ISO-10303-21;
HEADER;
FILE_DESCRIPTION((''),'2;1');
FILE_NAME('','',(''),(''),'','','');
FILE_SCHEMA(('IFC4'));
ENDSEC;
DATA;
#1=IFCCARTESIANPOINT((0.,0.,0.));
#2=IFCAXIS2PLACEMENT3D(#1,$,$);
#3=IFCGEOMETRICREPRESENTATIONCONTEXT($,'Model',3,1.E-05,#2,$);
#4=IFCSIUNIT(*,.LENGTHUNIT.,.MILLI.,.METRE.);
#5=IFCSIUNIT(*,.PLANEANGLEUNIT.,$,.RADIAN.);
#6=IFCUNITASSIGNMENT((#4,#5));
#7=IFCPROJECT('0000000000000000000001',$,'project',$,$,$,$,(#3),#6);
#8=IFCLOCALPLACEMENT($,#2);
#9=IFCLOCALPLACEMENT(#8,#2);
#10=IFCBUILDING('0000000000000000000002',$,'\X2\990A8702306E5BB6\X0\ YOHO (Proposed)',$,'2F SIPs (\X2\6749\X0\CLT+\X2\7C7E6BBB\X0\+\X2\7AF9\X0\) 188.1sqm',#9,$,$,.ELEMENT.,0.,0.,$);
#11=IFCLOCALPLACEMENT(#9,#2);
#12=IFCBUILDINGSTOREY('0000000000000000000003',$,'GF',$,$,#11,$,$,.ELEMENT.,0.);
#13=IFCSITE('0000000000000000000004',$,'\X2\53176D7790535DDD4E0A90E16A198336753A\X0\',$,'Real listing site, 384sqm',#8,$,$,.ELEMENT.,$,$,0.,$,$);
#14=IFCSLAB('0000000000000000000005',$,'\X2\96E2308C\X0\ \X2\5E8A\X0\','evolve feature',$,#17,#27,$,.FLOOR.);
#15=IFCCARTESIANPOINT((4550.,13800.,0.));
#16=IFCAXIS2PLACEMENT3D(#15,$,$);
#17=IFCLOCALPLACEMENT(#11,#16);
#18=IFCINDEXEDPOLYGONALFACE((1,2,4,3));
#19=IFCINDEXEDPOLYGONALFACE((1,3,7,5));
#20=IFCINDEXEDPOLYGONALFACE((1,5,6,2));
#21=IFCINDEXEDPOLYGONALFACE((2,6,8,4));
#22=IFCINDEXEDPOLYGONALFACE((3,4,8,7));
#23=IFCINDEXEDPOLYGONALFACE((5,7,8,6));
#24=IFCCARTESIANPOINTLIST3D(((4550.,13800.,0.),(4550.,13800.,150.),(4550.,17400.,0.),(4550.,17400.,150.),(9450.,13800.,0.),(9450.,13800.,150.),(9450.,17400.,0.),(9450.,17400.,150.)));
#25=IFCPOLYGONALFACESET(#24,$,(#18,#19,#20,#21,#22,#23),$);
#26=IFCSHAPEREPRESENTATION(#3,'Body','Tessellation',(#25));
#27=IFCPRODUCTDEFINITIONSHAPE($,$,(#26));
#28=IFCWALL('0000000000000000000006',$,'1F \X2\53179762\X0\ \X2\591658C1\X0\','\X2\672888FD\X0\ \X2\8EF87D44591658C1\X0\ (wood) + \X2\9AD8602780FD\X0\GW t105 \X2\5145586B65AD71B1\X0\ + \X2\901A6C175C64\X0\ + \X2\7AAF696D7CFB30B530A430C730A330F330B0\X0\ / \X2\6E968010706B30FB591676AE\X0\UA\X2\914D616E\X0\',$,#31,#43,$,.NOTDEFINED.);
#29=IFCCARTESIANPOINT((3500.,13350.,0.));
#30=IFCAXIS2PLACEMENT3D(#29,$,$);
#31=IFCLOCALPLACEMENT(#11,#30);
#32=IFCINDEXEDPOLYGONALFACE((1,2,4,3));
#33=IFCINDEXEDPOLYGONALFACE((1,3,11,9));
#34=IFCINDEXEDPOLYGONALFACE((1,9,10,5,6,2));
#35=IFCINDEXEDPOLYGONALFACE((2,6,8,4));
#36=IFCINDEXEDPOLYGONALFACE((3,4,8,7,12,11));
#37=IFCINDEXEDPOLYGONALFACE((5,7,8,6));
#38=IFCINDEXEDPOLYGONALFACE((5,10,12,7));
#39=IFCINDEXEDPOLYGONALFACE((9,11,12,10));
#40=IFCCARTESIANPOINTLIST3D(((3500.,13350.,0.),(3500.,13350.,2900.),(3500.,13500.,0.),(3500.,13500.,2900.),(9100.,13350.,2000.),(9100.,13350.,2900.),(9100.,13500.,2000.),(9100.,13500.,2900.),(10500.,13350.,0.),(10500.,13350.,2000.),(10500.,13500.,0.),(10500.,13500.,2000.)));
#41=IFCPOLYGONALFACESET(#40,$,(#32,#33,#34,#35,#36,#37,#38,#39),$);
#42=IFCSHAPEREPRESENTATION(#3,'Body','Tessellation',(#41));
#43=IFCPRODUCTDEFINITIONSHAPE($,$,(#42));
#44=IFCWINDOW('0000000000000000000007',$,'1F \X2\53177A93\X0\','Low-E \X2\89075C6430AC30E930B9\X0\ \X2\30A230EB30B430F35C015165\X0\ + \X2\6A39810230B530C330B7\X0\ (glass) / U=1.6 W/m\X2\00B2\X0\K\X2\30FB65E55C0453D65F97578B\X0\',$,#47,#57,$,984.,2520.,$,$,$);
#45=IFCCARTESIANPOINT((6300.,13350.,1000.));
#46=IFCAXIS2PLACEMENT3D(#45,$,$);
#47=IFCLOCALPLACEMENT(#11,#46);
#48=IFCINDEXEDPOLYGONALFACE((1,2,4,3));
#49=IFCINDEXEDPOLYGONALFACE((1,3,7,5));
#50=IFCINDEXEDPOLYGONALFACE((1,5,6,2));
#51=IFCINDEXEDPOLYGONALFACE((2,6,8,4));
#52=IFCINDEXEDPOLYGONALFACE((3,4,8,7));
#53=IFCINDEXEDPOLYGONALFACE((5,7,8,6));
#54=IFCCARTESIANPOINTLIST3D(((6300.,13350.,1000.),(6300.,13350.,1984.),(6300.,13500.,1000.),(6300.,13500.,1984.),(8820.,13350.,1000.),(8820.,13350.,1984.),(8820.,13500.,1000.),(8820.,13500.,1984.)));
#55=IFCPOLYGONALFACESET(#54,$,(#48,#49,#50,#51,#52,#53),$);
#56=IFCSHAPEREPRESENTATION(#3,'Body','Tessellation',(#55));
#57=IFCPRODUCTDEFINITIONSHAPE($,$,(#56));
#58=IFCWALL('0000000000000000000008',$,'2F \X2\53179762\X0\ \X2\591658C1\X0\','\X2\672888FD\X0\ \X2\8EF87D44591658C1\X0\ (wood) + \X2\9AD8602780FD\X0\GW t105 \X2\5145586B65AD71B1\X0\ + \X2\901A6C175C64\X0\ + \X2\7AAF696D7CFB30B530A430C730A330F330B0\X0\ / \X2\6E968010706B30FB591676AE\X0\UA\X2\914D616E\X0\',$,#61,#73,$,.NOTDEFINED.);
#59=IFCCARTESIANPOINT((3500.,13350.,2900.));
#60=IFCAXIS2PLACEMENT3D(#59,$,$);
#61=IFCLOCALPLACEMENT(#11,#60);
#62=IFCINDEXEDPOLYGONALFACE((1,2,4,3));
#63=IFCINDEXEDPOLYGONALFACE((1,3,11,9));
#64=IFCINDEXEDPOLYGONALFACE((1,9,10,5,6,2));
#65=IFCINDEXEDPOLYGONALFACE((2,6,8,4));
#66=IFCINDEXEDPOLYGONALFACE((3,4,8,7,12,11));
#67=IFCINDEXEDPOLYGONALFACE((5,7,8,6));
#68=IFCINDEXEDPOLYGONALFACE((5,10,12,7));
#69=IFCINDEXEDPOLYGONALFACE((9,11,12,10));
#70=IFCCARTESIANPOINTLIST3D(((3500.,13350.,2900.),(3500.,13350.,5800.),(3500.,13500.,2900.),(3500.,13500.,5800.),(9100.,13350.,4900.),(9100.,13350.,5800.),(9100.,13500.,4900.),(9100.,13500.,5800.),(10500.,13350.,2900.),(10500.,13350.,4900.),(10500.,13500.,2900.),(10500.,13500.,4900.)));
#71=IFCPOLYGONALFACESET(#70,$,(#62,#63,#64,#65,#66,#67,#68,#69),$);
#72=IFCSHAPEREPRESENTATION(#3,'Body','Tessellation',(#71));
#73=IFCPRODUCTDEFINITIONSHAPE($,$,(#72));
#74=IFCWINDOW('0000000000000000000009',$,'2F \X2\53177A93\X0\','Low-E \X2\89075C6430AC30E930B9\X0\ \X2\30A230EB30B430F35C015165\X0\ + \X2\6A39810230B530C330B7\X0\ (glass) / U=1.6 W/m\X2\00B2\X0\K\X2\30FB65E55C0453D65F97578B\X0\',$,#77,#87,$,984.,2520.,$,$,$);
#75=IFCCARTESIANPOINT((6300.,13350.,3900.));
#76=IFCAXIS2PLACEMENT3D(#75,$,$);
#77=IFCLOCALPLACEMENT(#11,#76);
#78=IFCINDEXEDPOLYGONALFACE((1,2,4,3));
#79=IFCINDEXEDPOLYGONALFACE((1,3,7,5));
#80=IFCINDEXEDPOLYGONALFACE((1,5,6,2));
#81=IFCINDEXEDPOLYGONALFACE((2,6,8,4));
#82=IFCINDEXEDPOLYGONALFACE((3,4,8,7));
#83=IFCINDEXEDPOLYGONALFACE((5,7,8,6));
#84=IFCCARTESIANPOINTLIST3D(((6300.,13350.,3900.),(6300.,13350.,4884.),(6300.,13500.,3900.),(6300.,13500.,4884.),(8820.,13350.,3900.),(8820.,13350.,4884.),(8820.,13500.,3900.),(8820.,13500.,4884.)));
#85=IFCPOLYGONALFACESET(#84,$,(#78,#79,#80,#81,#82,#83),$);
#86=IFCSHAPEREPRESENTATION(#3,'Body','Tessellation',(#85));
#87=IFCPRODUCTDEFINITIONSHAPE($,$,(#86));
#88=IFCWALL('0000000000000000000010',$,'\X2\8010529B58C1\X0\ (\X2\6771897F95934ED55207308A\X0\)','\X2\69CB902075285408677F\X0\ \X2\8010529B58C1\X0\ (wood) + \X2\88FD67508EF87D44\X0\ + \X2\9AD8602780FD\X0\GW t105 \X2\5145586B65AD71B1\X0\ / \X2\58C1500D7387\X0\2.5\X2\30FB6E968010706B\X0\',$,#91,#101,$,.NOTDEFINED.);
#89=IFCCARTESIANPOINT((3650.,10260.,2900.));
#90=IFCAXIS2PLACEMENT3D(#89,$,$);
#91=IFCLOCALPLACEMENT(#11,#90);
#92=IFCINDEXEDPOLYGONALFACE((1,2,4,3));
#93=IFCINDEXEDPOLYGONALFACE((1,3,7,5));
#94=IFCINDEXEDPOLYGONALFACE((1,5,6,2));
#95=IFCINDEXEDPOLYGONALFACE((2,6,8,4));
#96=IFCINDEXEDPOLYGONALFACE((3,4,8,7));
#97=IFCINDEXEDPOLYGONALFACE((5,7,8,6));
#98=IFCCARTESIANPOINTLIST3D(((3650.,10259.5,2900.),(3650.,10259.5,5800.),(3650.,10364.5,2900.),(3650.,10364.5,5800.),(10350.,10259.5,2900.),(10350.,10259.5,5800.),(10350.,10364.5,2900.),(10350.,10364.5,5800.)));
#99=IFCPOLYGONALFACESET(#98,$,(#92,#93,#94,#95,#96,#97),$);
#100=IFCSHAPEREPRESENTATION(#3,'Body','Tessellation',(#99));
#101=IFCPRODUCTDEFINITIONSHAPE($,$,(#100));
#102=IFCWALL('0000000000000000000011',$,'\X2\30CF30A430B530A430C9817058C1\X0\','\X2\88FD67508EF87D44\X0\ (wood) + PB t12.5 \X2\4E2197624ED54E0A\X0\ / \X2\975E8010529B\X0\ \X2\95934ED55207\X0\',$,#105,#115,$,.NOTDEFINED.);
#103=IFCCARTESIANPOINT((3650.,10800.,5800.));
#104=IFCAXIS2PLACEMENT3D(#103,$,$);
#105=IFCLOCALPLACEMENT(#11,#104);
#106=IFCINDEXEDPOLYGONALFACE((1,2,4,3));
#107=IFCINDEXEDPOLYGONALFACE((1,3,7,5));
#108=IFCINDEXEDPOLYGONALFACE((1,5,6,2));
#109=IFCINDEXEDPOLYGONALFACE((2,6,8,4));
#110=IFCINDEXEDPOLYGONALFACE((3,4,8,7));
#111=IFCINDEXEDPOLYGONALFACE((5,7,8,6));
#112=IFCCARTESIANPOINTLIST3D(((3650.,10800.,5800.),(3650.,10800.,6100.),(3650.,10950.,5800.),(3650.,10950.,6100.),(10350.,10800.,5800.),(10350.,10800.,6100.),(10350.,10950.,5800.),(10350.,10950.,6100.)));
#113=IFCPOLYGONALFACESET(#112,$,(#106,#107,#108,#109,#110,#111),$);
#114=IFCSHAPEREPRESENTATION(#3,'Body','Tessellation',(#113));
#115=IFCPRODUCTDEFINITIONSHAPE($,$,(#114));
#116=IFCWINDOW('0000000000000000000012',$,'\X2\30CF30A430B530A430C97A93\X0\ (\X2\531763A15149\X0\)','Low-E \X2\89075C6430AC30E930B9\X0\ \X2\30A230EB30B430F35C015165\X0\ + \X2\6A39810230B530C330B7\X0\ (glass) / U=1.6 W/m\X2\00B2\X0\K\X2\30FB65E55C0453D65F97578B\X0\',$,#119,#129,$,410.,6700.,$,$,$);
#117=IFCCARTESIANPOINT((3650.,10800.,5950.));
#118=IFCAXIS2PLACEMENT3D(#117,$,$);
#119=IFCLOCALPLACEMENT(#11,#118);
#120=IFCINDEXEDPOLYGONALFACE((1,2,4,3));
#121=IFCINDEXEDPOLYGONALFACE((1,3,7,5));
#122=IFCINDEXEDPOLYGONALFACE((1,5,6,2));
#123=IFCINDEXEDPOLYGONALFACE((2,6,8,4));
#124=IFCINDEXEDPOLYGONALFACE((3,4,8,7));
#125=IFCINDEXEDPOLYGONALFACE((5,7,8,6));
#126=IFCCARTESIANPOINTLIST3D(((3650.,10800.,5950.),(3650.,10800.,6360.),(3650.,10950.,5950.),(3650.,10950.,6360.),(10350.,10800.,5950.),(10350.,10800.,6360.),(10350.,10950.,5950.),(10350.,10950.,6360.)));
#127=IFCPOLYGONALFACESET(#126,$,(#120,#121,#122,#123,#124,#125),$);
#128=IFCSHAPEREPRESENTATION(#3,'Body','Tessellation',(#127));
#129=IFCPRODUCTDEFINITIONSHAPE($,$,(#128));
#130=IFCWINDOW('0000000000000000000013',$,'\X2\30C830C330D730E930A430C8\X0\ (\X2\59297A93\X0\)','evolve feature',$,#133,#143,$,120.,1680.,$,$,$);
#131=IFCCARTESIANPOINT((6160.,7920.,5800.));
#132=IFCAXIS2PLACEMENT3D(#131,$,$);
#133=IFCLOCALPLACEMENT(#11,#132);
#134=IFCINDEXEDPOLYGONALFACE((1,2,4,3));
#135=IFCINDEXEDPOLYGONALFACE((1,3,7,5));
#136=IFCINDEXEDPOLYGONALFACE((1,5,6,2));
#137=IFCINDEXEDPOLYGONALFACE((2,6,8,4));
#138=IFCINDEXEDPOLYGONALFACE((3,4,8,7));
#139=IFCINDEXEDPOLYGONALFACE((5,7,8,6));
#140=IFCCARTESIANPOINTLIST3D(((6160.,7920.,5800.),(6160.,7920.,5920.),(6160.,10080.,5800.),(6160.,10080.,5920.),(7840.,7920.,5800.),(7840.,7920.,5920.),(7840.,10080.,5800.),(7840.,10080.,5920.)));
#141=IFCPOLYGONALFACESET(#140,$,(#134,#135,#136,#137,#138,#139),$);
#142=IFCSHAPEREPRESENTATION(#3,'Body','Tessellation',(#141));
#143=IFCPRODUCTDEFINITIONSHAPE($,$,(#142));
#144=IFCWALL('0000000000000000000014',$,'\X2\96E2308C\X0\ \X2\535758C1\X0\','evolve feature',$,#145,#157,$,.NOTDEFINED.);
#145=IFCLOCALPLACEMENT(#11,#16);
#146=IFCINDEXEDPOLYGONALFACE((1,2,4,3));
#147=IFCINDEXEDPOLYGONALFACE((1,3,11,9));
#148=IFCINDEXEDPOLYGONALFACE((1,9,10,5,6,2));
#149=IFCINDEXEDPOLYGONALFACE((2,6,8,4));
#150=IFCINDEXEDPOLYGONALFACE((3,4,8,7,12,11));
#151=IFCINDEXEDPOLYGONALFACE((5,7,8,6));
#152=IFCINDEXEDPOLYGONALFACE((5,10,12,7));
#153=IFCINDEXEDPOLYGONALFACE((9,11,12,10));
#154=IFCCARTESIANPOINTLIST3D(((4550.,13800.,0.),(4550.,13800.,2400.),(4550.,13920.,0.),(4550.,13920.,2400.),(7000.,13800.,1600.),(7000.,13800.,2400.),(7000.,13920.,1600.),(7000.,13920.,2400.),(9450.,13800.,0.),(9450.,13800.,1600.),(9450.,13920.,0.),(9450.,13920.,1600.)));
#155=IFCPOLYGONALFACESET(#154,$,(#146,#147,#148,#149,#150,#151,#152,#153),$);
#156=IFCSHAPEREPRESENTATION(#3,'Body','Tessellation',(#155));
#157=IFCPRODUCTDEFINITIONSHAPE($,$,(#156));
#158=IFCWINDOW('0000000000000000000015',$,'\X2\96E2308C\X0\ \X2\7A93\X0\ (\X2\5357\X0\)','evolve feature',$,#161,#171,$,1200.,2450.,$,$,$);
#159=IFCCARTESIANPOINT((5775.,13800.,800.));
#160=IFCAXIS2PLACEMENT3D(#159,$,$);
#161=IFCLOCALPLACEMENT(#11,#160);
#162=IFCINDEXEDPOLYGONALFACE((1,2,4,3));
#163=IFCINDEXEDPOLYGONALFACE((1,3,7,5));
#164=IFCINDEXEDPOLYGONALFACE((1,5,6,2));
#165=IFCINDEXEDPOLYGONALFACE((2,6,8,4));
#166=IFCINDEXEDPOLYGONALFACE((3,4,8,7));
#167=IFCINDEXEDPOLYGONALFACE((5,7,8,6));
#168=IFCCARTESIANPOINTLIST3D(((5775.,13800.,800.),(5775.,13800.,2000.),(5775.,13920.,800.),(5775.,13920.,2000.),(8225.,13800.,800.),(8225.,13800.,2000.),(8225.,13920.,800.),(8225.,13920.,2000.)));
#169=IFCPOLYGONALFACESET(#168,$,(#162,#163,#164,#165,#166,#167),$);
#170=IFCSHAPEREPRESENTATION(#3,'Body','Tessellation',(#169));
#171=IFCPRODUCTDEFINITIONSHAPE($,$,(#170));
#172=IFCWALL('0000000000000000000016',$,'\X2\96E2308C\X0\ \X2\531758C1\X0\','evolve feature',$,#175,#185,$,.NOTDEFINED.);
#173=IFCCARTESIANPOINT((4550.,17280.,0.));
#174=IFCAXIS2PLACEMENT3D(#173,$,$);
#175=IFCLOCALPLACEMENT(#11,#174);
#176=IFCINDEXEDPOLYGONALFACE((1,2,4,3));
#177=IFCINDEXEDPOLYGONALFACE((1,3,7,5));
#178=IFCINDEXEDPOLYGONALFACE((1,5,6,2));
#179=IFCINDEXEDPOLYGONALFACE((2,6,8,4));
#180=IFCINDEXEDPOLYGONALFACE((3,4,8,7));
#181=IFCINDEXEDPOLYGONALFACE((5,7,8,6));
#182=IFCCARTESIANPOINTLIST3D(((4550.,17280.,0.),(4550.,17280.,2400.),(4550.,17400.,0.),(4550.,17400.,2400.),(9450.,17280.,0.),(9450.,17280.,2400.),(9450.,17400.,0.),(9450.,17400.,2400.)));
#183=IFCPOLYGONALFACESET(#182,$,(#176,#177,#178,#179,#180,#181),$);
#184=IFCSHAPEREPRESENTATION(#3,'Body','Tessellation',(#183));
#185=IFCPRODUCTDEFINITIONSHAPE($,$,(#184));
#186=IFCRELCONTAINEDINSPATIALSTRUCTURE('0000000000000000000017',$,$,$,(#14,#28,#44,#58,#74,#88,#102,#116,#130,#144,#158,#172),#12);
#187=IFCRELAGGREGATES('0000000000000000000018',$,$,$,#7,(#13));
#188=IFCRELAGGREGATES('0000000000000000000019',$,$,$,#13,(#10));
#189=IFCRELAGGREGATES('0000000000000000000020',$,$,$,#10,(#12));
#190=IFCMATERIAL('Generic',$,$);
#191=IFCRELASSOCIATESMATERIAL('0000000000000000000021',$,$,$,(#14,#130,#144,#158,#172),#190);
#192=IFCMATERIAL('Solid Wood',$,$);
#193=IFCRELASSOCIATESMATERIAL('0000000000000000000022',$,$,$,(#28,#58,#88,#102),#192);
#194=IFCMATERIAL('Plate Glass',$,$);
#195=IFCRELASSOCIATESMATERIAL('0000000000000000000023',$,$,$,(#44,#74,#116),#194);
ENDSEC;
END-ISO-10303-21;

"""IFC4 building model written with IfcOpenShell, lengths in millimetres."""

from ifc_helpers import new_model, si_unit, frame, frame_2d, origin, place, context, project, spatial, rectangle, extrude, material, element, fill, save


model = new_model("IFC4")

# Units and contexts
model_context = context("Model", 3, precision=1e-05, world=origin())
ifc_project = project(units=[si_unit("LENGTHUNIT", "METRE", prefix="MILLI"), si_unit("PLANEANGLEUNIT", "RADIAN")], contexts=[model_context])

# Site, building, storey
site_placement = place(None, origin())
site = spatial("IfcSite", under=ifc_project, at=site_placement, Name="北海道川上郡標茶町", ObjectType="Real listing site, 384sqm", CompositionType="ELEMENT", RefElevation=0.0)
building_placement = place(site_placement, origin())
building = spatial("IfcBuilding", under=site, at=building_placement, Name="養蜂の家 YOHO (Proposed)", ObjectType="2F SIPs (杉CLT+籾殻+竹) 188.1sqm", CompositionType="ELEMENT", ElevationOfRefHeight=0.0, ElevationOfTerrain=0.0)
storey_placement = place(building_placement, origin())
storey = spatial("IfcBuildingStorey", under=building, at=storey_placement, Name="GF", CompositionType="ELEMENT", Elevation=0.0)

# Slab
ifc_material_1 = material(Name="Generic")
slab_placement = place(storey_placement, frame((4550.0, 13800.0, 0.0)))
element("IfcSlab", 1, at=slab_placement, inside=storey, material=ifc_material_1, Name="離れ 床", Description="evolve feature", PredefinedType="FLOOR", context=model_context, shape_type="SweptSolid", body=[
    extrude(rectangle(XDim=4900.0, YDim=3600.0, at=frame_2d((2450.0, 1800.0))), frame((4550.0, 13800.0, 0.0)), (0.0, 0.0, 1.0), 150.0),
])

# Wall, opening, window
ifc_material_2 = material(Name="Solid Wood")
wall_1_placement = place(storey_placement, frame((3500.0, 13350.0, 0.0)))
wall_1 = element("IfcWall", 2, at=wall_1_placement, inside=storey, material=ifc_material_2, Name="1F 北面 外壁", Description="木製 軸組外壁 (wood) + 高性能GW t105 充填断熱 + 通気層 + 窯業系サイディング / 準耐火・外皮UA配慮", PredefinedType="NOTDEFINED", context=model_context, shape_type="SweptSolid", body=[
    extrude(rectangle(XDim=7000.0, YDim=150.0, at=frame_2d((3500.0, 75.0))), frame((3500.0, 13350.0, 0.0)), (0.0, 0.0, 1.0), 2900.0),
])
opening_1_placement = place(storey_placement, frame((6300.0, 13350.0, 1000.0)))
opening_1 = element("IfcOpeningElement", 3, at=opening_1_placement, cuts=wall_1, PredefinedType="NOTDEFINED", context=model_context, shape_type="SweptSolid", body=[
    extrude(rectangle(XDim=2520.0, YDim=150.0, at=frame_2d((1260.0, 75.0))), frame((6300.0, 13350.0, 1000.0)), (0.0, 0.0, 1.0), 984.0),
])
ifc_material_3 = material(Name="Plate Glass")
window_1_placement = place(storey_placement, frame((6300.0, 13350.0, 1000.0)))
window_1 = element("IfcWindow", 4, at=window_1_placement, inside=storey, material=ifc_material_3, Name="1F 北窓", Description="Low-E 複層ガラス アルゴン封入 + 樹脂サッシ (glass) / U=1.6 W/m²K・日射取得型", OverallHeight=984.0, OverallWidth=2520.0, context=model_context, shape_type="SweptSolid", body=[
    extrude(rectangle(XDim=2520.0, YDim=150.0, at=frame_2d((1260.0, 75.0))), frame((6300.0, 13350.0, 1000.0)), (0.0, 0.0, 1.0), 984.0),
])
fill(opening_1, window_1)

# Wall, opening, window
wall_2_placement = place(storey_placement, frame((3500.0, 13350.0, 2900.0)))
wall_2 = element("IfcWall", 5, at=wall_2_placement, inside=storey, material=ifc_material_2, Name="2F 北面 外壁", Description="木製 軸組外壁 (wood) + 高性能GW t105 充填断熱 + 通気層 + 窯業系サイディング / 準耐火・外皮UA配慮", PredefinedType="NOTDEFINED", context=model_context, shape_type="SweptSolid", body=[
    extrude(rectangle(XDim=7000.0, YDim=150.0, at=frame_2d((3500.0, 75.0))), frame((3500.0, 13350.0, 2900.0)), (0.0, 0.0, 1.0), 2900.0),
])
opening_2_placement = place(storey_placement, frame((6300.0, 13350.0, 3900.0)))
opening_2 = element("IfcOpeningElement", 6, at=opening_2_placement, cuts=wall_2, PredefinedType="NOTDEFINED", context=model_context, shape_type="SweptSolid", body=[
    extrude(rectangle(XDim=2520.0, YDim=150.0, at=frame_2d((1260.0, 75.0))), frame((6300.0, 13350.0, 3900.0)), (0.0, 0.0, 1.0), 984.0),
])
window_2_placement = place(storey_placement, frame((6300.0, 13350.0, 3900.0)))
window_2 = element("IfcWindow", 7, at=window_2_placement, inside=storey, material=ifc_material_3, Name="2F 北窓", Description="Low-E 複層ガラス アルゴン封入 + 樹脂サッシ (glass) / U=1.6 W/m²K・日射取得型", OverallHeight=984.0, OverallWidth=2520.0, context=model_context, shape_type="SweptSolid", body=[
    extrude(rectangle(XDim=2520.0, YDim=150.0, at=frame_2d((1260.0, 75.0))), frame((6300.0, 13350.0, 3900.0)), (0.0, 0.0, 1.0), 984.0),
])
fill(opening_2, window_2)

# Wall
wall_3_placement = place(storey_placement, frame((3650.0, 10260.0, 2900.0)))
element("IfcWall", 8, at=wall_3_placement, inside=storey, material=ifc_material_2, Name="耐力壁 (東西間仕切り)", Description="構造用合板 耐力壁 (wood) + 製材軸組 + 高性能GW t105 充填断熱 / 壁倍率2.5・準耐火", PredefinedType="NOTDEFINED", context=model_context, shape_type="SweptSolid", body=[
    extrude(rectangle(XDim=6700.0, YDim=105.0, at=frame_2d((3350.0, 52.0))), frame((3650.0, 10260.0, 2900.0)), (0.0, 0.0, 1.0), 2900.0),
])

# Wall, opening, window
wall_4_placement = place(storey_placement, frame((3650.0, 10800.0, 5800.0)))
wall_4 = element("IfcWall", 9, at=wall_4_placement, inside=storey, material=ifc_material_2, Name="ハイサイド腰壁", Description="製材軸組 (wood) + PB t12.5 両面仕上 / 非耐力 間仕切", PredefinedType="NOTDEFINED", context=model_context, shape_type="SweptSolid", body=[
    extrude(rectangle(XDim=6700.0, YDim=150.0, at=frame_2d((3350.0, 75.0))), frame((3650.0, 10800.0, 5800.0)), (0.0, 0.0, 1.0), 700.0),
])
opening_3_placement = place(storey_placement, frame((3650.0, 10800.0, 5950.0)))
opening_3 = element("IfcOpeningElement", 10, at=opening_3_placement, cuts=wall_4, PredefinedType="NOTDEFINED", context=model_context, shape_type="SweptSolid", body=[
    extrude(rectangle(XDim=6700.0, YDim=150.0, at=frame_2d((3350.0, 75.0))), frame((3650.0, 10800.0, 5950.0)), (0.0, 0.0, 1.0), 410.0),
])
window_3_placement = place(storey_placement, frame((3650.0, 10800.0, 5950.0)))
window_3 = element("IfcWindow", 11, at=window_3_placement, inside=storey, material=ifc_material_3, Name="ハイサイド窓 (北採光)", Description="Low-E 複層ガラス アルゴン封入 + 樹脂サッシ (glass) / U=1.6 W/m²K・日射取得型", OverallHeight=410.0, OverallWidth=6700.0, context=model_context, shape_type="SweptSolid", body=[
    extrude(rectangle(XDim=6700.0, YDim=150.0, at=frame_2d((3350.0, 75.0))), frame((3650.0, 10800.0, 5950.0)), (0.0, 0.0, 1.0), 410.0),
])
fill(opening_3, window_3)

# Window
window_4_placement = place(storey_placement, frame((6160.0, 7920.0, 5800.0)))
element("IfcWindow", 12, at=window_4_placement, inside=storey, material=ifc_material_1, Name="トップライト (天窓)", Description="evolve feature", OverallHeight=120.0, OverallWidth=1680.0, context=model_context, shape_type="SweptSolid", body=[
    extrude(rectangle(XDim=1680.0, YDim=2160.0, at=frame_2d((840.0, 1080.0))), frame((6160.0, 7920.0, 5800.0)), (0.0, 0.0, 1.0), 120.0),
])

# Wall, opening, window
wall_5_placement = place(storey_placement, frame((4550.0, 13800.0, 0.0)))
wall_5 = element("IfcWall", 13, at=wall_5_placement, inside=storey, material=ifc_material_1, Name="離れ 南壁", Description="evolve feature", PredefinedType="NOTDEFINED", context=model_context, shape_type="SweptSolid", body=[
    extrude(rectangle(XDim=4900.0, YDim=120.0, at=frame_2d((2450.0, 60.0))), frame((4550.0, 13800.0, 0.0)), (0.0, 0.0, 1.0), 2400.0),
])
opening_4_placement = place(storey_placement, frame((5775.0, 13800.0, 800.0)))
opening_4 = element("IfcOpeningElement", 14, at=opening_4_placement, cuts=wall_5, PredefinedType="NOTDEFINED", context=model_context, shape_type="SweptSolid", body=[
    extrude(rectangle(XDim=2450.0, YDim=120.0, at=frame_2d((1225.0, 60.0))), frame((5775.0, 13800.0, 800.0)), (0.0, 0.0, 1.0), 1200.0),
])
window_5_placement = place(storey_placement, frame((5775.0, 13800.0, 800.0)))
window_5 = element("IfcWindow", 15, at=window_5_placement, inside=storey, material=ifc_material_1, Name="離れ 窓 (南)", Description="evolve feature", OverallHeight=1200.0, OverallWidth=2450.0, context=model_context, shape_type="SweptSolid", body=[
    extrude(rectangle(XDim=2450.0, YDim=120.0, at=frame_2d((1225.0, 60.0))), frame((5775.0, 13800.0, 800.0)), (0.0, 0.0, 1.0), 1200.0),
])
fill(opening_4, window_5)

# Wall
wall_6_placement = place(storey_placement, frame((4550.0, 17280.0, 0.0)))
element("IfcWall", 16, at=wall_6_placement, inside=storey, material=ifc_material_1, Name="離れ 北壁", Description="evolve feature", PredefinedType="NOTDEFINED", context=model_context, shape_type="SweptSolid", body=[
    extrude(rectangle(XDim=4900.0, YDim=120.0, at=frame_2d((2450.0, 60.0))), frame((4550.0, 17280.0, 0.0)), (0.0, 0.0, 1.0), 2400.0),
])

save(model, "model.ifc")
